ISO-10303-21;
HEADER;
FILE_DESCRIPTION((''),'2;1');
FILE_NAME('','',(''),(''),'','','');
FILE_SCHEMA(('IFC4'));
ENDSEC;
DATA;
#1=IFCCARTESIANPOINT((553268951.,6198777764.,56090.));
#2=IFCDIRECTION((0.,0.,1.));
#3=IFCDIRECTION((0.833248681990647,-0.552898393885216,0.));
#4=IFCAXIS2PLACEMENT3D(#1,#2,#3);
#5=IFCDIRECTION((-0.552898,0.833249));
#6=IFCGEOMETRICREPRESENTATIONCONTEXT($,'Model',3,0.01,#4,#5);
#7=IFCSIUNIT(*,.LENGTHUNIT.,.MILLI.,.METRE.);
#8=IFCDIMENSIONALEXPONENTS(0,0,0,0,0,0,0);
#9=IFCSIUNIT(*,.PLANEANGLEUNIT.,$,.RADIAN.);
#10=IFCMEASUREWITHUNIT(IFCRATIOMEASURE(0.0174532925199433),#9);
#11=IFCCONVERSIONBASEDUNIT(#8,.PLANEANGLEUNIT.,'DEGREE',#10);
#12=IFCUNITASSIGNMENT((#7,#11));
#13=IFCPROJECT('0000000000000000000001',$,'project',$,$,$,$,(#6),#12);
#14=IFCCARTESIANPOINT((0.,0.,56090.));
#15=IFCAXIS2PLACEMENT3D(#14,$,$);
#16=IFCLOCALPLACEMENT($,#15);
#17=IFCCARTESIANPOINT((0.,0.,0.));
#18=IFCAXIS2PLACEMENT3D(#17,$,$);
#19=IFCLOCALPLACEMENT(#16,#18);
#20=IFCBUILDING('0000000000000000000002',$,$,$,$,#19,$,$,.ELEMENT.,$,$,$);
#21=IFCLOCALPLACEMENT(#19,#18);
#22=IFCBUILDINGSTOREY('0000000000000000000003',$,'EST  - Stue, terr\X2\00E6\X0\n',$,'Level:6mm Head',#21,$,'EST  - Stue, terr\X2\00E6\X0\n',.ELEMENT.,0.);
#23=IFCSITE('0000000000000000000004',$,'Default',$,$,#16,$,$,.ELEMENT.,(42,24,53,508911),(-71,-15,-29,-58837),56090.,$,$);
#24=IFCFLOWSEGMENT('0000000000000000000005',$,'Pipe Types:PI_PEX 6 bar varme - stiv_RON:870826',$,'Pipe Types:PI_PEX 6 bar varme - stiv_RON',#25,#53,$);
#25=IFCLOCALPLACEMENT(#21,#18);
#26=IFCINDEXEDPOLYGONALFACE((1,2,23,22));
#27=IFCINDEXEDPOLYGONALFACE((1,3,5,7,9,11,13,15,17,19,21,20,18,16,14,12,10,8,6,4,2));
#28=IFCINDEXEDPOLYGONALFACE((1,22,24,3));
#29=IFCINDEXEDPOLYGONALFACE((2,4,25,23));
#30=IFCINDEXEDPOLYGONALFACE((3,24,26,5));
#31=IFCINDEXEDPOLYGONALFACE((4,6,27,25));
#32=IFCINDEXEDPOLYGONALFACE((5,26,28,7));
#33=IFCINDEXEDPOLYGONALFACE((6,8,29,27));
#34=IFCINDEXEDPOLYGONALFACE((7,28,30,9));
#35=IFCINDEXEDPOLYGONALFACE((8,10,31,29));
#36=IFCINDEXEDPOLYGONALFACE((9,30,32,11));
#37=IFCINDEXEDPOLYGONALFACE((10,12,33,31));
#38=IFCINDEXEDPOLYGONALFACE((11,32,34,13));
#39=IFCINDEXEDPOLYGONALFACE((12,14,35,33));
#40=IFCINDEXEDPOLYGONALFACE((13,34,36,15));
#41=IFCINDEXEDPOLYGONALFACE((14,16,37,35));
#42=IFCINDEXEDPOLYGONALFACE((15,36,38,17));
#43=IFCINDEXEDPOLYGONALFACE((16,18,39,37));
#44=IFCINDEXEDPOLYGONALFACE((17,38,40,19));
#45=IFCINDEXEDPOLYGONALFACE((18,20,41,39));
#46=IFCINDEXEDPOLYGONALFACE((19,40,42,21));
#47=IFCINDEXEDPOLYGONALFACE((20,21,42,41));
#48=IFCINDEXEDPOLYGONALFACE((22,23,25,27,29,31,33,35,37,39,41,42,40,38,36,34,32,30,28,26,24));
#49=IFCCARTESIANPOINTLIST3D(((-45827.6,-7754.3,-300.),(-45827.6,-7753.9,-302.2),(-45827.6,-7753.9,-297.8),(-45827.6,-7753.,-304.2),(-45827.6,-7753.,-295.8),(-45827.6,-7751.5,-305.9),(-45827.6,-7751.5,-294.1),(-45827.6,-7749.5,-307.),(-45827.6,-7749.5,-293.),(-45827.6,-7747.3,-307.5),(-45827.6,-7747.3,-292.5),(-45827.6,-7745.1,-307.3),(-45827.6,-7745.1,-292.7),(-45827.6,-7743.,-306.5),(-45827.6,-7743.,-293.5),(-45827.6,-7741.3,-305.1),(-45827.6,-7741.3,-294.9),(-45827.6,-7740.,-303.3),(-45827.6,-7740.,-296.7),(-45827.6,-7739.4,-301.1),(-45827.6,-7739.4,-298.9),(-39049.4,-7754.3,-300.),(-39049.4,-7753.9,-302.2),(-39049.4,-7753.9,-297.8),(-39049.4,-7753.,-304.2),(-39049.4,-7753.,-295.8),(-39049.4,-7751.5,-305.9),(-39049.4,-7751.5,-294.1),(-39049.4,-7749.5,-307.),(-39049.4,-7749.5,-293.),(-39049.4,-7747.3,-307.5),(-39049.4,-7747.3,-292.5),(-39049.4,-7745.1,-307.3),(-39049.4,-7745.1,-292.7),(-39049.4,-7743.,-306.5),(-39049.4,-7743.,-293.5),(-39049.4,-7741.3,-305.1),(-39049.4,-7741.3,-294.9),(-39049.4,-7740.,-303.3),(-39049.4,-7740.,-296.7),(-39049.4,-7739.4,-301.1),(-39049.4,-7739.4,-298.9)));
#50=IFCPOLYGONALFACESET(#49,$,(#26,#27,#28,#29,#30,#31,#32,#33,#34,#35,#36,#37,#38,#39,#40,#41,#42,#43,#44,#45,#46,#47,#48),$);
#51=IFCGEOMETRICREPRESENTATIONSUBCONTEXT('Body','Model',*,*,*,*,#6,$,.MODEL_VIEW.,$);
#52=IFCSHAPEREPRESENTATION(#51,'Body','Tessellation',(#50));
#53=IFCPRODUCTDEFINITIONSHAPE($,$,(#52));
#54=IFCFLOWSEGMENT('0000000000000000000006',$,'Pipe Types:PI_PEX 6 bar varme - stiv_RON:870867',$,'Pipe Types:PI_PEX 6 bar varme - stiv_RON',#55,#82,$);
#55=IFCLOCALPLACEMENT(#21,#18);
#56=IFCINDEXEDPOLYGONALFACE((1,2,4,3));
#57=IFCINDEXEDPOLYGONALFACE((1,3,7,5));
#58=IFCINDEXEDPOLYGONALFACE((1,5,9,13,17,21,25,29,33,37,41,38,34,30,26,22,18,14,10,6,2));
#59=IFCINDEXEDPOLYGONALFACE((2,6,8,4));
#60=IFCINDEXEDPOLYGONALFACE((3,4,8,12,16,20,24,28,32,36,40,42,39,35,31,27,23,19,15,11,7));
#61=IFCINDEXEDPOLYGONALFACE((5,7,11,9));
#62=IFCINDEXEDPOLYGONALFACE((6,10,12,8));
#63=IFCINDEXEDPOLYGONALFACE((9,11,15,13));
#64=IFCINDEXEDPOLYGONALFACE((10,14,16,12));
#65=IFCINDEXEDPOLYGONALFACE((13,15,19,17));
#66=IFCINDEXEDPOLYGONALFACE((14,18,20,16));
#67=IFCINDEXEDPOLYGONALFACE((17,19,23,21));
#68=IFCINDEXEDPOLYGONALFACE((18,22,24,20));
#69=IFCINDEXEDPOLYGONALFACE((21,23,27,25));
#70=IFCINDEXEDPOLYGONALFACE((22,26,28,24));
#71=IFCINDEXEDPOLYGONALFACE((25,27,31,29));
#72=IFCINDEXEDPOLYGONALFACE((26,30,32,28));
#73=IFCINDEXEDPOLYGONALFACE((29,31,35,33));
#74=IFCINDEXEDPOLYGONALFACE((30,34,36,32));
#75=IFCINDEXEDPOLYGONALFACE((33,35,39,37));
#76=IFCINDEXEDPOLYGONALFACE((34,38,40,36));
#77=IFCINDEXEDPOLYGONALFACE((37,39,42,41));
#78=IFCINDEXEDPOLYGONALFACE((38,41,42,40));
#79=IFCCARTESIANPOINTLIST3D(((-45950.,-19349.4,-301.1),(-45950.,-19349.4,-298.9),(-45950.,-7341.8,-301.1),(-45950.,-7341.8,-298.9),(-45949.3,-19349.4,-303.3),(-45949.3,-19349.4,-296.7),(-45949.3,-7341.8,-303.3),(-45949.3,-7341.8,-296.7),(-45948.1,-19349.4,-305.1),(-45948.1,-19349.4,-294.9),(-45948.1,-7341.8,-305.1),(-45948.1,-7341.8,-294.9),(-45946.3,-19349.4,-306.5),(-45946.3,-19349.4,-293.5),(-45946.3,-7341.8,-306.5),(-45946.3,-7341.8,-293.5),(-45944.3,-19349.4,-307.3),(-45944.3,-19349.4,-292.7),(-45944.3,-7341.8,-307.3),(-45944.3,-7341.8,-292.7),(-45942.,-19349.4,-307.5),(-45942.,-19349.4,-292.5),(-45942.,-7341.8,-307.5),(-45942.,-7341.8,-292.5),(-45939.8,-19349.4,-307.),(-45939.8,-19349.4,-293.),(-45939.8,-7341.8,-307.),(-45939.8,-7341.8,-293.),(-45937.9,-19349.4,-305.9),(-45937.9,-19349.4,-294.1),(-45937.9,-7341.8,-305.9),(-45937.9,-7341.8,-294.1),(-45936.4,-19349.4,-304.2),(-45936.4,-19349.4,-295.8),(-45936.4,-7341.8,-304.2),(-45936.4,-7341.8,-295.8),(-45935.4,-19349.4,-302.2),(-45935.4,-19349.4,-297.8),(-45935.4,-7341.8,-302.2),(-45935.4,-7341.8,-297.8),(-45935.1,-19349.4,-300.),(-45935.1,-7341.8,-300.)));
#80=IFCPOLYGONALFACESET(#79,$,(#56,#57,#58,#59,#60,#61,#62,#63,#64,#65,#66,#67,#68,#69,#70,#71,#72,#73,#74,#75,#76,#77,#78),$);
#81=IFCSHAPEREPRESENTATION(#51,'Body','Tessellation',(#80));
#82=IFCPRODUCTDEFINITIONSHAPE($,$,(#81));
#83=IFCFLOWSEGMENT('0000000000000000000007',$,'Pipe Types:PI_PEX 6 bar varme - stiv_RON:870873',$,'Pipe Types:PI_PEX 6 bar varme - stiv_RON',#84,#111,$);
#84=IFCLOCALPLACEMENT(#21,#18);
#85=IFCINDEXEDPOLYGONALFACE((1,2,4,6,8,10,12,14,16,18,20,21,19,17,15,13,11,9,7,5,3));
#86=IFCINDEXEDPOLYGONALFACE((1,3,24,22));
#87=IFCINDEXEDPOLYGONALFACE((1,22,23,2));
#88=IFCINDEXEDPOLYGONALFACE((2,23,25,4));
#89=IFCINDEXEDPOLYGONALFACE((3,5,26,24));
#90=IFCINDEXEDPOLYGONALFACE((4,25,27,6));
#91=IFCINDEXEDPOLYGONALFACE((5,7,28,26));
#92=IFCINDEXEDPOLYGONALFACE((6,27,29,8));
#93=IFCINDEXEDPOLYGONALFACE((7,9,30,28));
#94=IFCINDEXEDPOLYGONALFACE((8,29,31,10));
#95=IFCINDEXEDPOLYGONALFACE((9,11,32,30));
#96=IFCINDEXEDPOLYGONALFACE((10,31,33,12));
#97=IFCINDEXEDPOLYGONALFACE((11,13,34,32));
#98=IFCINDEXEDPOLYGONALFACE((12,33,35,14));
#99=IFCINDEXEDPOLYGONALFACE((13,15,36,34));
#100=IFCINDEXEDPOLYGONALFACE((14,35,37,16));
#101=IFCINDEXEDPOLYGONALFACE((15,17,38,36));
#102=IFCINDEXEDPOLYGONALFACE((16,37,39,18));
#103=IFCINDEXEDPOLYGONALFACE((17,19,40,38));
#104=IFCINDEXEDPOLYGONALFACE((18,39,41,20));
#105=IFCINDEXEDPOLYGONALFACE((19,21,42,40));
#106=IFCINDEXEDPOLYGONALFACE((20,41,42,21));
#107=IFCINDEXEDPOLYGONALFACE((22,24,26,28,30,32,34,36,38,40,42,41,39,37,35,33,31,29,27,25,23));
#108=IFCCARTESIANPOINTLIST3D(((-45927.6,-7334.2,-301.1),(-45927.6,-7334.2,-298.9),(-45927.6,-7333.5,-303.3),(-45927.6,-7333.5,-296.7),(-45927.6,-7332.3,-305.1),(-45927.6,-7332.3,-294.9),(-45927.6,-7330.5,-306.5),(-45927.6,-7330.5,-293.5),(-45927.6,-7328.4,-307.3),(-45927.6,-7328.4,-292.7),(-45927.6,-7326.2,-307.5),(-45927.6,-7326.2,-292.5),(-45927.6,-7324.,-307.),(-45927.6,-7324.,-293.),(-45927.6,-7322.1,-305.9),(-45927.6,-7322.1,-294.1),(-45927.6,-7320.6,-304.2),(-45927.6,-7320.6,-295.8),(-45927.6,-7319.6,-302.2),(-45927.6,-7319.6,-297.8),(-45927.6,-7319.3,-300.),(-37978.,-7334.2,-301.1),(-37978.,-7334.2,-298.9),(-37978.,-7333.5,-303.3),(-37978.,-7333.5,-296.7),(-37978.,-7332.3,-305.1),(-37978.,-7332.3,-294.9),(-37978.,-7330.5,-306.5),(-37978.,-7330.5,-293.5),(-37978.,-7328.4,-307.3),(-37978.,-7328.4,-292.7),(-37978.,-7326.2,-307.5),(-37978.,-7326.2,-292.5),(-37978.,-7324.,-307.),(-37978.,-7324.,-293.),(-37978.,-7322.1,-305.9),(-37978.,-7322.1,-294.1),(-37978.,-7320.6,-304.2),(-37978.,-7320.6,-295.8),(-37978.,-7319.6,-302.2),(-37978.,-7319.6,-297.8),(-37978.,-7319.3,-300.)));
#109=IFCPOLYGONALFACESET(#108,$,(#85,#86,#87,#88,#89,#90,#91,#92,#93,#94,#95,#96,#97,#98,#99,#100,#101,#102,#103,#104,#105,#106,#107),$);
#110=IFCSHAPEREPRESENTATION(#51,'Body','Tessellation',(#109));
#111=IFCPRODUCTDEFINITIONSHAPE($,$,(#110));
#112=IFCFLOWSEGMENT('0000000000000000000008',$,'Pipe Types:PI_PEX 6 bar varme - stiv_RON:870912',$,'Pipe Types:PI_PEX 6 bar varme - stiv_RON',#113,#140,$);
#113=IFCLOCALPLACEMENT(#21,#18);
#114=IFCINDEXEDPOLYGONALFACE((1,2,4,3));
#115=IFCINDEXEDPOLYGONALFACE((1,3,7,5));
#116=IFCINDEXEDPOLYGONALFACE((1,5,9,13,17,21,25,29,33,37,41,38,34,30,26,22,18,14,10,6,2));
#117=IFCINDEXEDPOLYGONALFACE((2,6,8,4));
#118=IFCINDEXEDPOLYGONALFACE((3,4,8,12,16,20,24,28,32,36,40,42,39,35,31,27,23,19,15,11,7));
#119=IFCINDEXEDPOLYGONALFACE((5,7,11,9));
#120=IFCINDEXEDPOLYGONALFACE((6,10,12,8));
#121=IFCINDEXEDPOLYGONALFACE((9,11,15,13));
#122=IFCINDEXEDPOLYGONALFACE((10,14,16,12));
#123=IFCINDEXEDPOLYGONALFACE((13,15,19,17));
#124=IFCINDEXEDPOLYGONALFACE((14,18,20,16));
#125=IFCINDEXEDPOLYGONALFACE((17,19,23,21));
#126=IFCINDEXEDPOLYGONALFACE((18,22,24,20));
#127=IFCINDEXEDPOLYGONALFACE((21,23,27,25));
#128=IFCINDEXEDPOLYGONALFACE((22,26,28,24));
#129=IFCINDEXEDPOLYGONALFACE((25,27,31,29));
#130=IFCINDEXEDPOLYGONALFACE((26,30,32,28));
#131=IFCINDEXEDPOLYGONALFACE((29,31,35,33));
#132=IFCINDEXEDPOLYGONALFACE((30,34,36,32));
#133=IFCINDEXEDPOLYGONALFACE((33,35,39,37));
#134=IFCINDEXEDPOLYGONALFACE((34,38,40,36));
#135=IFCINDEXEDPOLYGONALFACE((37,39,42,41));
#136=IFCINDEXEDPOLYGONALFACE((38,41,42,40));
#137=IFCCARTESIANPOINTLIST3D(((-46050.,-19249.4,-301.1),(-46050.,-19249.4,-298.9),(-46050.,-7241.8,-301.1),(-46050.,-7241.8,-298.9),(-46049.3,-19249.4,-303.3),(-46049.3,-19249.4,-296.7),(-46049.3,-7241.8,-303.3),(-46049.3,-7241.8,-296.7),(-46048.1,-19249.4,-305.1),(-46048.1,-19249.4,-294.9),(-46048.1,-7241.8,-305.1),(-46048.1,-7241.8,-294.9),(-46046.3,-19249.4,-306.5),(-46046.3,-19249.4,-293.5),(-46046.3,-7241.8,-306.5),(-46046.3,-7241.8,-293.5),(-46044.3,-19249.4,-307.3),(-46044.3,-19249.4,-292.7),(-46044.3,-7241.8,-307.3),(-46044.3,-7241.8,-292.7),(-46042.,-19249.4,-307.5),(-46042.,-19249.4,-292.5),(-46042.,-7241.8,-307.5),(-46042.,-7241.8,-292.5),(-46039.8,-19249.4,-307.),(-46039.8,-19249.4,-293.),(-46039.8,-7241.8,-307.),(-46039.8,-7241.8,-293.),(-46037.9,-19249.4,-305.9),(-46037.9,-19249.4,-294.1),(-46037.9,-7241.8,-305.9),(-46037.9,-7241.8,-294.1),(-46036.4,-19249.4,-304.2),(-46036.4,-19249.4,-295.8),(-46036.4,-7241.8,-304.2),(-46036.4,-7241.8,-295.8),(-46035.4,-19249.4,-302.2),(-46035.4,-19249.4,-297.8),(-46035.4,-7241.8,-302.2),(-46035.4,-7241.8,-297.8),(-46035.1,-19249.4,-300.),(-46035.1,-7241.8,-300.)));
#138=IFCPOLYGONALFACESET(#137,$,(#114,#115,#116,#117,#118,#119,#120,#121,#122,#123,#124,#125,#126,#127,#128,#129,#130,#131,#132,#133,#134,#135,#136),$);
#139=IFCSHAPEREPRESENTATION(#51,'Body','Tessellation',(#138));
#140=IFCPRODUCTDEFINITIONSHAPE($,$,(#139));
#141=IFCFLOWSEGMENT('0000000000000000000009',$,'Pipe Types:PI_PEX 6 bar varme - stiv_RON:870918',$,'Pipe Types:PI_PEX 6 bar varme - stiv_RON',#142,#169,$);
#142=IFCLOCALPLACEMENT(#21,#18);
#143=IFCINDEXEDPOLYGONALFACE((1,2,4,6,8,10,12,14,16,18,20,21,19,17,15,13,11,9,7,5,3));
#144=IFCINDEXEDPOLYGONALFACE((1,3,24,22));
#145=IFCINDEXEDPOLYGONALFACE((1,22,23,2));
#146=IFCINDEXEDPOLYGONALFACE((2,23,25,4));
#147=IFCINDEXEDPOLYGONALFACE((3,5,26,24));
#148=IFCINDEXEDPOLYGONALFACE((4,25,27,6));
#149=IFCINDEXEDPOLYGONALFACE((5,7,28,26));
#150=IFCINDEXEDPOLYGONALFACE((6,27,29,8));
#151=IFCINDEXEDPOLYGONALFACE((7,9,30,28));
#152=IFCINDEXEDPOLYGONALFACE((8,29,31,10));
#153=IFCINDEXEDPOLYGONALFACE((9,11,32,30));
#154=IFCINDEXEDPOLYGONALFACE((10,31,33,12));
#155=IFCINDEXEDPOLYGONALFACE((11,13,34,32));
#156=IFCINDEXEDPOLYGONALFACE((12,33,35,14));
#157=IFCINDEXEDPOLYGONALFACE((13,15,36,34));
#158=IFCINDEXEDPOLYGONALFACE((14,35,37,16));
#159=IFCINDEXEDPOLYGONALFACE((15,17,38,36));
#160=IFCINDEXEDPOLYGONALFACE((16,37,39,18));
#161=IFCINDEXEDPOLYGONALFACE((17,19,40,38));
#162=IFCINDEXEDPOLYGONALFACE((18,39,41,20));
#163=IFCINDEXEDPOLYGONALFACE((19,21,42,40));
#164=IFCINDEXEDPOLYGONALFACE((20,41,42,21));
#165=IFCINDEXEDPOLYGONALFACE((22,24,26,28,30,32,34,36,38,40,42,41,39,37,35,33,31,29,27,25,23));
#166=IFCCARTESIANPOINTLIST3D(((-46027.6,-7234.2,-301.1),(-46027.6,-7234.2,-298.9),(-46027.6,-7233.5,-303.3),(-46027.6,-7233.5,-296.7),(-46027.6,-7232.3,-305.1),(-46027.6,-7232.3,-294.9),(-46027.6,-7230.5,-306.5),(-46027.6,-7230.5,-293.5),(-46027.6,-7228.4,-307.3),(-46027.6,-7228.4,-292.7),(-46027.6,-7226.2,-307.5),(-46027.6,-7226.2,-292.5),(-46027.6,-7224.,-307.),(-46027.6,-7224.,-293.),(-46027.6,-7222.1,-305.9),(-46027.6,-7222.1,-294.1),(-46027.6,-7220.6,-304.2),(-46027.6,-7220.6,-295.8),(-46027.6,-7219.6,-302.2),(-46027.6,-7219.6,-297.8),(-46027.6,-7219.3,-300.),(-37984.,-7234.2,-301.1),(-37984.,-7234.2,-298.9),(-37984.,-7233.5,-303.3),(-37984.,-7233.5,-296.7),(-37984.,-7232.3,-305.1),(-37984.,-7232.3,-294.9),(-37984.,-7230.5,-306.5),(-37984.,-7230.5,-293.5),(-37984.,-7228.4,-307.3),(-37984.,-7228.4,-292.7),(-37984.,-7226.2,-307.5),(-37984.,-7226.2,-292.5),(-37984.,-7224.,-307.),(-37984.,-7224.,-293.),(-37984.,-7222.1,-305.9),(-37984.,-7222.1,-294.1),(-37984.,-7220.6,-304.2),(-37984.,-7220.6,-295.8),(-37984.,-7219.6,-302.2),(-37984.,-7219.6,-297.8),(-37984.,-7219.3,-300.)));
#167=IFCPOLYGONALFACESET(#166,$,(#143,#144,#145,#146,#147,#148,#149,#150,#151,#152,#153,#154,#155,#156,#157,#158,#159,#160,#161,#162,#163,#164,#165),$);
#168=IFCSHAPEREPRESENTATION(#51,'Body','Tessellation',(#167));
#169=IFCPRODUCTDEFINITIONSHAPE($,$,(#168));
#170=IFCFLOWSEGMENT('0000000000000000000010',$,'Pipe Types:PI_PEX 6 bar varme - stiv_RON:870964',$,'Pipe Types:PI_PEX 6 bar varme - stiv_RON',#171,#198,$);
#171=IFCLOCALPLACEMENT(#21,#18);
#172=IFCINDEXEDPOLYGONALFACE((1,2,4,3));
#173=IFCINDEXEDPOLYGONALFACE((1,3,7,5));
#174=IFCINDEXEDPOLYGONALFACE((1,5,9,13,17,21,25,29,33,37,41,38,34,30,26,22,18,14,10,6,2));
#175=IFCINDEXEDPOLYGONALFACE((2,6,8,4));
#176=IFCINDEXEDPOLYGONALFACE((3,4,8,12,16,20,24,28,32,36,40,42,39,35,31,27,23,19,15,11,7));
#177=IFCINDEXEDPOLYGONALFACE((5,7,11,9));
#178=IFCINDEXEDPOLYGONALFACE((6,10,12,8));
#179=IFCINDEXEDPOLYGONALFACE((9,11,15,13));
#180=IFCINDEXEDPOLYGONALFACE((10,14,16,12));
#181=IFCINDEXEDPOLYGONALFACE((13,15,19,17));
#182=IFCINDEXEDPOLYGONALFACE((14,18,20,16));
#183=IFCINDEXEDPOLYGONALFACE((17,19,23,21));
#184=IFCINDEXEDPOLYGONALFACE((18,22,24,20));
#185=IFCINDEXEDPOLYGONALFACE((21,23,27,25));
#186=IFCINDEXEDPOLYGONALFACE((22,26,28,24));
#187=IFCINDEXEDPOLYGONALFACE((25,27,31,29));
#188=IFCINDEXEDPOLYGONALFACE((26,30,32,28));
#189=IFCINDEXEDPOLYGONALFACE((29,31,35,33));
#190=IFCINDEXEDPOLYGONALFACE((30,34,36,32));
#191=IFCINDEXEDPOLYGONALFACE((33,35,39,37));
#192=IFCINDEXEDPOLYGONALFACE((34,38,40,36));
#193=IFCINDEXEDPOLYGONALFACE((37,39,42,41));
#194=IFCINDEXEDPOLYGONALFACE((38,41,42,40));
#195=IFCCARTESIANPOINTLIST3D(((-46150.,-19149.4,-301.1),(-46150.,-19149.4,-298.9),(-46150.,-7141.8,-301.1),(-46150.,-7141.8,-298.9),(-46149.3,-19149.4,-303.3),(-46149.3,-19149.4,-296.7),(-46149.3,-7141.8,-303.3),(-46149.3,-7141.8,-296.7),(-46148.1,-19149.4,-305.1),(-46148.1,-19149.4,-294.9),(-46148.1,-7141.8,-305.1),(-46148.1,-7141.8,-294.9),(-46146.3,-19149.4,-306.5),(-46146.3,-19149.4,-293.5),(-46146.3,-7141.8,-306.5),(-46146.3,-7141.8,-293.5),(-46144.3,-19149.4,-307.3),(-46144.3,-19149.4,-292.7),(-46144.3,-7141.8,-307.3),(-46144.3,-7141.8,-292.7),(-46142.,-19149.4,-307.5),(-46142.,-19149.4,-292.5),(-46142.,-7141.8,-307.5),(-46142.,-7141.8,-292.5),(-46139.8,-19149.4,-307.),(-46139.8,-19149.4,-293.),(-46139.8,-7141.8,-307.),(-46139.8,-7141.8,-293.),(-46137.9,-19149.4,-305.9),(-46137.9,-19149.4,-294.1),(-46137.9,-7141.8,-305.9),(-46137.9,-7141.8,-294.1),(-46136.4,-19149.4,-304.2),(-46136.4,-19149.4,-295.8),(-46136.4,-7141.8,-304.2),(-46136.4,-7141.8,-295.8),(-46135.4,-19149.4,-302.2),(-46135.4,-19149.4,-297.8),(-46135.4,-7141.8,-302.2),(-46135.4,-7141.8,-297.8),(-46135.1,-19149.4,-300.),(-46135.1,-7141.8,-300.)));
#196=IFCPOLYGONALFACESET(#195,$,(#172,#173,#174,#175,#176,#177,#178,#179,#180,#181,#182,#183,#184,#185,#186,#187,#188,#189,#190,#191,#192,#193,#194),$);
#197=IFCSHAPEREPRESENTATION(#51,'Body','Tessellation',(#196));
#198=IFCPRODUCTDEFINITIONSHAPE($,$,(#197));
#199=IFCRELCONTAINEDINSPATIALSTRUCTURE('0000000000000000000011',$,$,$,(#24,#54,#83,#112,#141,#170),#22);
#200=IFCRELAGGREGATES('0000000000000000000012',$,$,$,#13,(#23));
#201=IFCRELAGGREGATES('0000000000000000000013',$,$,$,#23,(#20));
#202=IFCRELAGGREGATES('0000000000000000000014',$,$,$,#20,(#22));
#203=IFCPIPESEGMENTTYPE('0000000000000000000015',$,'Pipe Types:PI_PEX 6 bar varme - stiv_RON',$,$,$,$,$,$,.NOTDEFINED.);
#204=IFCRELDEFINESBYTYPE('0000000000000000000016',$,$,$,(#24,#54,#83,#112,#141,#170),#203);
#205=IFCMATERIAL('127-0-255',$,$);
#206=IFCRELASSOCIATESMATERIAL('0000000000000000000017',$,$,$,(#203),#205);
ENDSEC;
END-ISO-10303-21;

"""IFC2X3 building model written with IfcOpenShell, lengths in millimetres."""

from ifc_helpers import new_model, entity, si_unit, converted_unit, direction, frame, frame_2d, origin, origin_2d_with_axis, place, context, subcontext, project, spatial, circle, extrude, material, type_object, element, save


model = new_model("IFC2X3")

# Units and contexts
model_context = context("Model", 3, precision=0.01, world=frame((553268951.0, 6198777764.0, 56090.0), z_axis=(0.0, 0.0, 1.0), x_axis=(0.833248681990647, -0.552898393885216, 0.0)), true_north=direction((-0.552898, 0.833249)))
body_context = subcontext(model_context, "Body", "Model", "MODEL_VIEW")
ifc_project = project(units=[si_unit("LENGTHUNIT", "METRE", prefix="MILLI"), converted_unit("PLANEANGLEUNIT", "DEGREE", entity("IfcRatioMeasure", 0.0174532925199433), si_unit("PLANEANGLEUNIT", "RADIAN"), dimensions=[0, 0, 0, 0, 0, 0, 0])], contexts=[model_context])

# Site, building, storey
site_placement = place(None, frame((0.0, 0.0, 56090.0)))
site = spatial("IfcSite", under=ifc_project, at=site_placement, Name="Default", CompositionType="ELEMENT", RefLatitude=(42, 24, 53, 508911), RefLongitude=(-71, -15, -29, -58837), RefElevation=56090.0)
building_placement = place(site_placement, origin())
building = spatial("IfcBuilding", under=site, at=building_placement, CompositionType="ELEMENT")
storey_placement = place(building_placement, frame((0.0, 0.0, 0.0)))
storey = spatial("IfcBuildingStorey", under=building, at=storey_placement, Name="EST  - Stue, terræn", ObjectType="Level:6mm Head", LongName="EST  - Stue, terræn", CompositionType="ELEMENT", Elevation=0.0)

# Flow segments
ifc_material = material(Name="127-0-255")
pipe_segment_type = type_object("IfcPipeSegmentType", Name="Pipe Types:PI_PEX 6 bar varme - stiv_RON", PredefinedType="NOTDEFINED", material=ifc_material)
flow_segment_1_placement = place(storey_placement, origin())
element("IfcFlowSegment", 1, at=flow_segment_1_placement, inside=storey, type_object=pipe_segment_type, Name="Pipe Types:PI_PEX 6 bar varme - stiv_RON:870826", ObjectType="Pipe Types:PI_PEX 6 bar varme - stiv_RON", context=body_context, shape_type="SweptSolid", body=[
    extrude(circle(Radius=7.5, at=origin_2d_with_axis()), frame((-45827.6, -7746.8, -300.0), z_axis=(1.0, 0.0, 0.0), x_axis=(0.0, -1.0, 0.0)), (0.0, 0.0, 1.0), 6778.2),
])
flow_segment_2_placement = place(storey_placement, origin())
element("IfcFlowSegment", 2, at=flow_segment_2_placement, inside=storey, type_object=pipe_segment_type, Name="Pipe Types:PI_PEX 6 bar varme - stiv_RON:870867", ObjectType="Pipe Types:PI_PEX 6 bar varme - stiv_RON", context=body_context, shape_type="SweptSolid", body=[
    extrude(circle(Radius=7.5, at=origin_2d_with_axis()), frame((-45942.6, -19349.4, -300.0), z_axis=(0.0, 1.0, 0.0), x_axis=(1.0, 0.0, 0.0)), (0.0, 0.0, 1.0), 12007.6),
])
flow_segment_3_placement = place(storey_placement, origin())
element("IfcFlowSegment", 3, at=flow_segment_3_placement, inside=storey, type_object=pipe_segment_type, Name="Pipe Types:PI_PEX 6 bar varme - stiv_RON:870873", ObjectType="Pipe Types:PI_PEX 6 bar varme - stiv_RON", context=body_context, shape_type="SweptSolid", body=[
    extrude(circle(Radius=7.5, at=frame_2d((0.0, 0.0), x_axis=(1.0, 0.0))), frame((-45927.6, -7326.8, -300.0), z_axis=(1.0, 0.0, 0.0), x_axis=(0.0, 1.0, 0.0)), (0.0, 0.0, 1.0), 7949.6),
])
flow_segment_4_placement = place(storey_placement, origin())
element("IfcFlowSegment", 4, at=flow_segment_4_placement, inside=storey, type_object=pipe_segment_type, Name="Pipe Types:PI_PEX 6 bar varme - stiv_RON:870912", ObjectType="Pipe Types:PI_PEX 6 bar varme - stiv_RON", context=body_context, shape_type="SweptSolid", body=[
    extrude(circle(Radius=7.5, at=origin_2d_with_axis()), frame((-46042.6, -19249.4, -300.0), z_axis=(0.0, 1.0, 0.0), x_axis=(1.0, 0.0, 0.0)), (0.0, 0.0, 1.0), 12007.6),
])
flow_segment_5_placement = place(storey_placement, origin())
element("IfcFlowSegment", 5, at=flow_segment_5_placement, inside=storey, type_object=pipe_segment_type, Name="Pipe Types:PI_PEX 6 bar varme - stiv_RON:870918", ObjectType="Pipe Types:PI_PEX 6 bar varme - stiv_RON", context=body_context, shape_type="SweptSolid", body=[
    extrude(circle(Radius=7.5, at=frame_2d((0.0, 0.0), x_axis=(1.0, 0.0))), frame((-46027.6, -7226.8, -300.0), z_axis=(1.0, 0.0, 0.0), x_axis=(0.0, 1.0, 0.0)), (0.0, 0.0, 1.0), 8043.6),
])
flow_segment_6_placement = place(storey_placement, origin())
element("IfcFlowSegment", 6, at=flow_segment_6_placement, inside=storey, type_object=pipe_segment_type, Name="Pipe Types:PI_PEX 6 bar varme - stiv_RON:870964", ObjectType="Pipe Types:PI_PEX 6 bar varme - stiv_RON", context=body_context, shape_type="SweptSolid", body=[
    extrude(circle(Radius=7.5, at=origin_2d_with_axis()), frame((-46142.6, -19149.4, -300.0), z_axis=(0.0, 1.0, 0.0), x_axis=(1.0, 0.0, 0.0)), (0.0, 0.0, 1.0), 12007.6),
])

save(model, "model.ifc")
